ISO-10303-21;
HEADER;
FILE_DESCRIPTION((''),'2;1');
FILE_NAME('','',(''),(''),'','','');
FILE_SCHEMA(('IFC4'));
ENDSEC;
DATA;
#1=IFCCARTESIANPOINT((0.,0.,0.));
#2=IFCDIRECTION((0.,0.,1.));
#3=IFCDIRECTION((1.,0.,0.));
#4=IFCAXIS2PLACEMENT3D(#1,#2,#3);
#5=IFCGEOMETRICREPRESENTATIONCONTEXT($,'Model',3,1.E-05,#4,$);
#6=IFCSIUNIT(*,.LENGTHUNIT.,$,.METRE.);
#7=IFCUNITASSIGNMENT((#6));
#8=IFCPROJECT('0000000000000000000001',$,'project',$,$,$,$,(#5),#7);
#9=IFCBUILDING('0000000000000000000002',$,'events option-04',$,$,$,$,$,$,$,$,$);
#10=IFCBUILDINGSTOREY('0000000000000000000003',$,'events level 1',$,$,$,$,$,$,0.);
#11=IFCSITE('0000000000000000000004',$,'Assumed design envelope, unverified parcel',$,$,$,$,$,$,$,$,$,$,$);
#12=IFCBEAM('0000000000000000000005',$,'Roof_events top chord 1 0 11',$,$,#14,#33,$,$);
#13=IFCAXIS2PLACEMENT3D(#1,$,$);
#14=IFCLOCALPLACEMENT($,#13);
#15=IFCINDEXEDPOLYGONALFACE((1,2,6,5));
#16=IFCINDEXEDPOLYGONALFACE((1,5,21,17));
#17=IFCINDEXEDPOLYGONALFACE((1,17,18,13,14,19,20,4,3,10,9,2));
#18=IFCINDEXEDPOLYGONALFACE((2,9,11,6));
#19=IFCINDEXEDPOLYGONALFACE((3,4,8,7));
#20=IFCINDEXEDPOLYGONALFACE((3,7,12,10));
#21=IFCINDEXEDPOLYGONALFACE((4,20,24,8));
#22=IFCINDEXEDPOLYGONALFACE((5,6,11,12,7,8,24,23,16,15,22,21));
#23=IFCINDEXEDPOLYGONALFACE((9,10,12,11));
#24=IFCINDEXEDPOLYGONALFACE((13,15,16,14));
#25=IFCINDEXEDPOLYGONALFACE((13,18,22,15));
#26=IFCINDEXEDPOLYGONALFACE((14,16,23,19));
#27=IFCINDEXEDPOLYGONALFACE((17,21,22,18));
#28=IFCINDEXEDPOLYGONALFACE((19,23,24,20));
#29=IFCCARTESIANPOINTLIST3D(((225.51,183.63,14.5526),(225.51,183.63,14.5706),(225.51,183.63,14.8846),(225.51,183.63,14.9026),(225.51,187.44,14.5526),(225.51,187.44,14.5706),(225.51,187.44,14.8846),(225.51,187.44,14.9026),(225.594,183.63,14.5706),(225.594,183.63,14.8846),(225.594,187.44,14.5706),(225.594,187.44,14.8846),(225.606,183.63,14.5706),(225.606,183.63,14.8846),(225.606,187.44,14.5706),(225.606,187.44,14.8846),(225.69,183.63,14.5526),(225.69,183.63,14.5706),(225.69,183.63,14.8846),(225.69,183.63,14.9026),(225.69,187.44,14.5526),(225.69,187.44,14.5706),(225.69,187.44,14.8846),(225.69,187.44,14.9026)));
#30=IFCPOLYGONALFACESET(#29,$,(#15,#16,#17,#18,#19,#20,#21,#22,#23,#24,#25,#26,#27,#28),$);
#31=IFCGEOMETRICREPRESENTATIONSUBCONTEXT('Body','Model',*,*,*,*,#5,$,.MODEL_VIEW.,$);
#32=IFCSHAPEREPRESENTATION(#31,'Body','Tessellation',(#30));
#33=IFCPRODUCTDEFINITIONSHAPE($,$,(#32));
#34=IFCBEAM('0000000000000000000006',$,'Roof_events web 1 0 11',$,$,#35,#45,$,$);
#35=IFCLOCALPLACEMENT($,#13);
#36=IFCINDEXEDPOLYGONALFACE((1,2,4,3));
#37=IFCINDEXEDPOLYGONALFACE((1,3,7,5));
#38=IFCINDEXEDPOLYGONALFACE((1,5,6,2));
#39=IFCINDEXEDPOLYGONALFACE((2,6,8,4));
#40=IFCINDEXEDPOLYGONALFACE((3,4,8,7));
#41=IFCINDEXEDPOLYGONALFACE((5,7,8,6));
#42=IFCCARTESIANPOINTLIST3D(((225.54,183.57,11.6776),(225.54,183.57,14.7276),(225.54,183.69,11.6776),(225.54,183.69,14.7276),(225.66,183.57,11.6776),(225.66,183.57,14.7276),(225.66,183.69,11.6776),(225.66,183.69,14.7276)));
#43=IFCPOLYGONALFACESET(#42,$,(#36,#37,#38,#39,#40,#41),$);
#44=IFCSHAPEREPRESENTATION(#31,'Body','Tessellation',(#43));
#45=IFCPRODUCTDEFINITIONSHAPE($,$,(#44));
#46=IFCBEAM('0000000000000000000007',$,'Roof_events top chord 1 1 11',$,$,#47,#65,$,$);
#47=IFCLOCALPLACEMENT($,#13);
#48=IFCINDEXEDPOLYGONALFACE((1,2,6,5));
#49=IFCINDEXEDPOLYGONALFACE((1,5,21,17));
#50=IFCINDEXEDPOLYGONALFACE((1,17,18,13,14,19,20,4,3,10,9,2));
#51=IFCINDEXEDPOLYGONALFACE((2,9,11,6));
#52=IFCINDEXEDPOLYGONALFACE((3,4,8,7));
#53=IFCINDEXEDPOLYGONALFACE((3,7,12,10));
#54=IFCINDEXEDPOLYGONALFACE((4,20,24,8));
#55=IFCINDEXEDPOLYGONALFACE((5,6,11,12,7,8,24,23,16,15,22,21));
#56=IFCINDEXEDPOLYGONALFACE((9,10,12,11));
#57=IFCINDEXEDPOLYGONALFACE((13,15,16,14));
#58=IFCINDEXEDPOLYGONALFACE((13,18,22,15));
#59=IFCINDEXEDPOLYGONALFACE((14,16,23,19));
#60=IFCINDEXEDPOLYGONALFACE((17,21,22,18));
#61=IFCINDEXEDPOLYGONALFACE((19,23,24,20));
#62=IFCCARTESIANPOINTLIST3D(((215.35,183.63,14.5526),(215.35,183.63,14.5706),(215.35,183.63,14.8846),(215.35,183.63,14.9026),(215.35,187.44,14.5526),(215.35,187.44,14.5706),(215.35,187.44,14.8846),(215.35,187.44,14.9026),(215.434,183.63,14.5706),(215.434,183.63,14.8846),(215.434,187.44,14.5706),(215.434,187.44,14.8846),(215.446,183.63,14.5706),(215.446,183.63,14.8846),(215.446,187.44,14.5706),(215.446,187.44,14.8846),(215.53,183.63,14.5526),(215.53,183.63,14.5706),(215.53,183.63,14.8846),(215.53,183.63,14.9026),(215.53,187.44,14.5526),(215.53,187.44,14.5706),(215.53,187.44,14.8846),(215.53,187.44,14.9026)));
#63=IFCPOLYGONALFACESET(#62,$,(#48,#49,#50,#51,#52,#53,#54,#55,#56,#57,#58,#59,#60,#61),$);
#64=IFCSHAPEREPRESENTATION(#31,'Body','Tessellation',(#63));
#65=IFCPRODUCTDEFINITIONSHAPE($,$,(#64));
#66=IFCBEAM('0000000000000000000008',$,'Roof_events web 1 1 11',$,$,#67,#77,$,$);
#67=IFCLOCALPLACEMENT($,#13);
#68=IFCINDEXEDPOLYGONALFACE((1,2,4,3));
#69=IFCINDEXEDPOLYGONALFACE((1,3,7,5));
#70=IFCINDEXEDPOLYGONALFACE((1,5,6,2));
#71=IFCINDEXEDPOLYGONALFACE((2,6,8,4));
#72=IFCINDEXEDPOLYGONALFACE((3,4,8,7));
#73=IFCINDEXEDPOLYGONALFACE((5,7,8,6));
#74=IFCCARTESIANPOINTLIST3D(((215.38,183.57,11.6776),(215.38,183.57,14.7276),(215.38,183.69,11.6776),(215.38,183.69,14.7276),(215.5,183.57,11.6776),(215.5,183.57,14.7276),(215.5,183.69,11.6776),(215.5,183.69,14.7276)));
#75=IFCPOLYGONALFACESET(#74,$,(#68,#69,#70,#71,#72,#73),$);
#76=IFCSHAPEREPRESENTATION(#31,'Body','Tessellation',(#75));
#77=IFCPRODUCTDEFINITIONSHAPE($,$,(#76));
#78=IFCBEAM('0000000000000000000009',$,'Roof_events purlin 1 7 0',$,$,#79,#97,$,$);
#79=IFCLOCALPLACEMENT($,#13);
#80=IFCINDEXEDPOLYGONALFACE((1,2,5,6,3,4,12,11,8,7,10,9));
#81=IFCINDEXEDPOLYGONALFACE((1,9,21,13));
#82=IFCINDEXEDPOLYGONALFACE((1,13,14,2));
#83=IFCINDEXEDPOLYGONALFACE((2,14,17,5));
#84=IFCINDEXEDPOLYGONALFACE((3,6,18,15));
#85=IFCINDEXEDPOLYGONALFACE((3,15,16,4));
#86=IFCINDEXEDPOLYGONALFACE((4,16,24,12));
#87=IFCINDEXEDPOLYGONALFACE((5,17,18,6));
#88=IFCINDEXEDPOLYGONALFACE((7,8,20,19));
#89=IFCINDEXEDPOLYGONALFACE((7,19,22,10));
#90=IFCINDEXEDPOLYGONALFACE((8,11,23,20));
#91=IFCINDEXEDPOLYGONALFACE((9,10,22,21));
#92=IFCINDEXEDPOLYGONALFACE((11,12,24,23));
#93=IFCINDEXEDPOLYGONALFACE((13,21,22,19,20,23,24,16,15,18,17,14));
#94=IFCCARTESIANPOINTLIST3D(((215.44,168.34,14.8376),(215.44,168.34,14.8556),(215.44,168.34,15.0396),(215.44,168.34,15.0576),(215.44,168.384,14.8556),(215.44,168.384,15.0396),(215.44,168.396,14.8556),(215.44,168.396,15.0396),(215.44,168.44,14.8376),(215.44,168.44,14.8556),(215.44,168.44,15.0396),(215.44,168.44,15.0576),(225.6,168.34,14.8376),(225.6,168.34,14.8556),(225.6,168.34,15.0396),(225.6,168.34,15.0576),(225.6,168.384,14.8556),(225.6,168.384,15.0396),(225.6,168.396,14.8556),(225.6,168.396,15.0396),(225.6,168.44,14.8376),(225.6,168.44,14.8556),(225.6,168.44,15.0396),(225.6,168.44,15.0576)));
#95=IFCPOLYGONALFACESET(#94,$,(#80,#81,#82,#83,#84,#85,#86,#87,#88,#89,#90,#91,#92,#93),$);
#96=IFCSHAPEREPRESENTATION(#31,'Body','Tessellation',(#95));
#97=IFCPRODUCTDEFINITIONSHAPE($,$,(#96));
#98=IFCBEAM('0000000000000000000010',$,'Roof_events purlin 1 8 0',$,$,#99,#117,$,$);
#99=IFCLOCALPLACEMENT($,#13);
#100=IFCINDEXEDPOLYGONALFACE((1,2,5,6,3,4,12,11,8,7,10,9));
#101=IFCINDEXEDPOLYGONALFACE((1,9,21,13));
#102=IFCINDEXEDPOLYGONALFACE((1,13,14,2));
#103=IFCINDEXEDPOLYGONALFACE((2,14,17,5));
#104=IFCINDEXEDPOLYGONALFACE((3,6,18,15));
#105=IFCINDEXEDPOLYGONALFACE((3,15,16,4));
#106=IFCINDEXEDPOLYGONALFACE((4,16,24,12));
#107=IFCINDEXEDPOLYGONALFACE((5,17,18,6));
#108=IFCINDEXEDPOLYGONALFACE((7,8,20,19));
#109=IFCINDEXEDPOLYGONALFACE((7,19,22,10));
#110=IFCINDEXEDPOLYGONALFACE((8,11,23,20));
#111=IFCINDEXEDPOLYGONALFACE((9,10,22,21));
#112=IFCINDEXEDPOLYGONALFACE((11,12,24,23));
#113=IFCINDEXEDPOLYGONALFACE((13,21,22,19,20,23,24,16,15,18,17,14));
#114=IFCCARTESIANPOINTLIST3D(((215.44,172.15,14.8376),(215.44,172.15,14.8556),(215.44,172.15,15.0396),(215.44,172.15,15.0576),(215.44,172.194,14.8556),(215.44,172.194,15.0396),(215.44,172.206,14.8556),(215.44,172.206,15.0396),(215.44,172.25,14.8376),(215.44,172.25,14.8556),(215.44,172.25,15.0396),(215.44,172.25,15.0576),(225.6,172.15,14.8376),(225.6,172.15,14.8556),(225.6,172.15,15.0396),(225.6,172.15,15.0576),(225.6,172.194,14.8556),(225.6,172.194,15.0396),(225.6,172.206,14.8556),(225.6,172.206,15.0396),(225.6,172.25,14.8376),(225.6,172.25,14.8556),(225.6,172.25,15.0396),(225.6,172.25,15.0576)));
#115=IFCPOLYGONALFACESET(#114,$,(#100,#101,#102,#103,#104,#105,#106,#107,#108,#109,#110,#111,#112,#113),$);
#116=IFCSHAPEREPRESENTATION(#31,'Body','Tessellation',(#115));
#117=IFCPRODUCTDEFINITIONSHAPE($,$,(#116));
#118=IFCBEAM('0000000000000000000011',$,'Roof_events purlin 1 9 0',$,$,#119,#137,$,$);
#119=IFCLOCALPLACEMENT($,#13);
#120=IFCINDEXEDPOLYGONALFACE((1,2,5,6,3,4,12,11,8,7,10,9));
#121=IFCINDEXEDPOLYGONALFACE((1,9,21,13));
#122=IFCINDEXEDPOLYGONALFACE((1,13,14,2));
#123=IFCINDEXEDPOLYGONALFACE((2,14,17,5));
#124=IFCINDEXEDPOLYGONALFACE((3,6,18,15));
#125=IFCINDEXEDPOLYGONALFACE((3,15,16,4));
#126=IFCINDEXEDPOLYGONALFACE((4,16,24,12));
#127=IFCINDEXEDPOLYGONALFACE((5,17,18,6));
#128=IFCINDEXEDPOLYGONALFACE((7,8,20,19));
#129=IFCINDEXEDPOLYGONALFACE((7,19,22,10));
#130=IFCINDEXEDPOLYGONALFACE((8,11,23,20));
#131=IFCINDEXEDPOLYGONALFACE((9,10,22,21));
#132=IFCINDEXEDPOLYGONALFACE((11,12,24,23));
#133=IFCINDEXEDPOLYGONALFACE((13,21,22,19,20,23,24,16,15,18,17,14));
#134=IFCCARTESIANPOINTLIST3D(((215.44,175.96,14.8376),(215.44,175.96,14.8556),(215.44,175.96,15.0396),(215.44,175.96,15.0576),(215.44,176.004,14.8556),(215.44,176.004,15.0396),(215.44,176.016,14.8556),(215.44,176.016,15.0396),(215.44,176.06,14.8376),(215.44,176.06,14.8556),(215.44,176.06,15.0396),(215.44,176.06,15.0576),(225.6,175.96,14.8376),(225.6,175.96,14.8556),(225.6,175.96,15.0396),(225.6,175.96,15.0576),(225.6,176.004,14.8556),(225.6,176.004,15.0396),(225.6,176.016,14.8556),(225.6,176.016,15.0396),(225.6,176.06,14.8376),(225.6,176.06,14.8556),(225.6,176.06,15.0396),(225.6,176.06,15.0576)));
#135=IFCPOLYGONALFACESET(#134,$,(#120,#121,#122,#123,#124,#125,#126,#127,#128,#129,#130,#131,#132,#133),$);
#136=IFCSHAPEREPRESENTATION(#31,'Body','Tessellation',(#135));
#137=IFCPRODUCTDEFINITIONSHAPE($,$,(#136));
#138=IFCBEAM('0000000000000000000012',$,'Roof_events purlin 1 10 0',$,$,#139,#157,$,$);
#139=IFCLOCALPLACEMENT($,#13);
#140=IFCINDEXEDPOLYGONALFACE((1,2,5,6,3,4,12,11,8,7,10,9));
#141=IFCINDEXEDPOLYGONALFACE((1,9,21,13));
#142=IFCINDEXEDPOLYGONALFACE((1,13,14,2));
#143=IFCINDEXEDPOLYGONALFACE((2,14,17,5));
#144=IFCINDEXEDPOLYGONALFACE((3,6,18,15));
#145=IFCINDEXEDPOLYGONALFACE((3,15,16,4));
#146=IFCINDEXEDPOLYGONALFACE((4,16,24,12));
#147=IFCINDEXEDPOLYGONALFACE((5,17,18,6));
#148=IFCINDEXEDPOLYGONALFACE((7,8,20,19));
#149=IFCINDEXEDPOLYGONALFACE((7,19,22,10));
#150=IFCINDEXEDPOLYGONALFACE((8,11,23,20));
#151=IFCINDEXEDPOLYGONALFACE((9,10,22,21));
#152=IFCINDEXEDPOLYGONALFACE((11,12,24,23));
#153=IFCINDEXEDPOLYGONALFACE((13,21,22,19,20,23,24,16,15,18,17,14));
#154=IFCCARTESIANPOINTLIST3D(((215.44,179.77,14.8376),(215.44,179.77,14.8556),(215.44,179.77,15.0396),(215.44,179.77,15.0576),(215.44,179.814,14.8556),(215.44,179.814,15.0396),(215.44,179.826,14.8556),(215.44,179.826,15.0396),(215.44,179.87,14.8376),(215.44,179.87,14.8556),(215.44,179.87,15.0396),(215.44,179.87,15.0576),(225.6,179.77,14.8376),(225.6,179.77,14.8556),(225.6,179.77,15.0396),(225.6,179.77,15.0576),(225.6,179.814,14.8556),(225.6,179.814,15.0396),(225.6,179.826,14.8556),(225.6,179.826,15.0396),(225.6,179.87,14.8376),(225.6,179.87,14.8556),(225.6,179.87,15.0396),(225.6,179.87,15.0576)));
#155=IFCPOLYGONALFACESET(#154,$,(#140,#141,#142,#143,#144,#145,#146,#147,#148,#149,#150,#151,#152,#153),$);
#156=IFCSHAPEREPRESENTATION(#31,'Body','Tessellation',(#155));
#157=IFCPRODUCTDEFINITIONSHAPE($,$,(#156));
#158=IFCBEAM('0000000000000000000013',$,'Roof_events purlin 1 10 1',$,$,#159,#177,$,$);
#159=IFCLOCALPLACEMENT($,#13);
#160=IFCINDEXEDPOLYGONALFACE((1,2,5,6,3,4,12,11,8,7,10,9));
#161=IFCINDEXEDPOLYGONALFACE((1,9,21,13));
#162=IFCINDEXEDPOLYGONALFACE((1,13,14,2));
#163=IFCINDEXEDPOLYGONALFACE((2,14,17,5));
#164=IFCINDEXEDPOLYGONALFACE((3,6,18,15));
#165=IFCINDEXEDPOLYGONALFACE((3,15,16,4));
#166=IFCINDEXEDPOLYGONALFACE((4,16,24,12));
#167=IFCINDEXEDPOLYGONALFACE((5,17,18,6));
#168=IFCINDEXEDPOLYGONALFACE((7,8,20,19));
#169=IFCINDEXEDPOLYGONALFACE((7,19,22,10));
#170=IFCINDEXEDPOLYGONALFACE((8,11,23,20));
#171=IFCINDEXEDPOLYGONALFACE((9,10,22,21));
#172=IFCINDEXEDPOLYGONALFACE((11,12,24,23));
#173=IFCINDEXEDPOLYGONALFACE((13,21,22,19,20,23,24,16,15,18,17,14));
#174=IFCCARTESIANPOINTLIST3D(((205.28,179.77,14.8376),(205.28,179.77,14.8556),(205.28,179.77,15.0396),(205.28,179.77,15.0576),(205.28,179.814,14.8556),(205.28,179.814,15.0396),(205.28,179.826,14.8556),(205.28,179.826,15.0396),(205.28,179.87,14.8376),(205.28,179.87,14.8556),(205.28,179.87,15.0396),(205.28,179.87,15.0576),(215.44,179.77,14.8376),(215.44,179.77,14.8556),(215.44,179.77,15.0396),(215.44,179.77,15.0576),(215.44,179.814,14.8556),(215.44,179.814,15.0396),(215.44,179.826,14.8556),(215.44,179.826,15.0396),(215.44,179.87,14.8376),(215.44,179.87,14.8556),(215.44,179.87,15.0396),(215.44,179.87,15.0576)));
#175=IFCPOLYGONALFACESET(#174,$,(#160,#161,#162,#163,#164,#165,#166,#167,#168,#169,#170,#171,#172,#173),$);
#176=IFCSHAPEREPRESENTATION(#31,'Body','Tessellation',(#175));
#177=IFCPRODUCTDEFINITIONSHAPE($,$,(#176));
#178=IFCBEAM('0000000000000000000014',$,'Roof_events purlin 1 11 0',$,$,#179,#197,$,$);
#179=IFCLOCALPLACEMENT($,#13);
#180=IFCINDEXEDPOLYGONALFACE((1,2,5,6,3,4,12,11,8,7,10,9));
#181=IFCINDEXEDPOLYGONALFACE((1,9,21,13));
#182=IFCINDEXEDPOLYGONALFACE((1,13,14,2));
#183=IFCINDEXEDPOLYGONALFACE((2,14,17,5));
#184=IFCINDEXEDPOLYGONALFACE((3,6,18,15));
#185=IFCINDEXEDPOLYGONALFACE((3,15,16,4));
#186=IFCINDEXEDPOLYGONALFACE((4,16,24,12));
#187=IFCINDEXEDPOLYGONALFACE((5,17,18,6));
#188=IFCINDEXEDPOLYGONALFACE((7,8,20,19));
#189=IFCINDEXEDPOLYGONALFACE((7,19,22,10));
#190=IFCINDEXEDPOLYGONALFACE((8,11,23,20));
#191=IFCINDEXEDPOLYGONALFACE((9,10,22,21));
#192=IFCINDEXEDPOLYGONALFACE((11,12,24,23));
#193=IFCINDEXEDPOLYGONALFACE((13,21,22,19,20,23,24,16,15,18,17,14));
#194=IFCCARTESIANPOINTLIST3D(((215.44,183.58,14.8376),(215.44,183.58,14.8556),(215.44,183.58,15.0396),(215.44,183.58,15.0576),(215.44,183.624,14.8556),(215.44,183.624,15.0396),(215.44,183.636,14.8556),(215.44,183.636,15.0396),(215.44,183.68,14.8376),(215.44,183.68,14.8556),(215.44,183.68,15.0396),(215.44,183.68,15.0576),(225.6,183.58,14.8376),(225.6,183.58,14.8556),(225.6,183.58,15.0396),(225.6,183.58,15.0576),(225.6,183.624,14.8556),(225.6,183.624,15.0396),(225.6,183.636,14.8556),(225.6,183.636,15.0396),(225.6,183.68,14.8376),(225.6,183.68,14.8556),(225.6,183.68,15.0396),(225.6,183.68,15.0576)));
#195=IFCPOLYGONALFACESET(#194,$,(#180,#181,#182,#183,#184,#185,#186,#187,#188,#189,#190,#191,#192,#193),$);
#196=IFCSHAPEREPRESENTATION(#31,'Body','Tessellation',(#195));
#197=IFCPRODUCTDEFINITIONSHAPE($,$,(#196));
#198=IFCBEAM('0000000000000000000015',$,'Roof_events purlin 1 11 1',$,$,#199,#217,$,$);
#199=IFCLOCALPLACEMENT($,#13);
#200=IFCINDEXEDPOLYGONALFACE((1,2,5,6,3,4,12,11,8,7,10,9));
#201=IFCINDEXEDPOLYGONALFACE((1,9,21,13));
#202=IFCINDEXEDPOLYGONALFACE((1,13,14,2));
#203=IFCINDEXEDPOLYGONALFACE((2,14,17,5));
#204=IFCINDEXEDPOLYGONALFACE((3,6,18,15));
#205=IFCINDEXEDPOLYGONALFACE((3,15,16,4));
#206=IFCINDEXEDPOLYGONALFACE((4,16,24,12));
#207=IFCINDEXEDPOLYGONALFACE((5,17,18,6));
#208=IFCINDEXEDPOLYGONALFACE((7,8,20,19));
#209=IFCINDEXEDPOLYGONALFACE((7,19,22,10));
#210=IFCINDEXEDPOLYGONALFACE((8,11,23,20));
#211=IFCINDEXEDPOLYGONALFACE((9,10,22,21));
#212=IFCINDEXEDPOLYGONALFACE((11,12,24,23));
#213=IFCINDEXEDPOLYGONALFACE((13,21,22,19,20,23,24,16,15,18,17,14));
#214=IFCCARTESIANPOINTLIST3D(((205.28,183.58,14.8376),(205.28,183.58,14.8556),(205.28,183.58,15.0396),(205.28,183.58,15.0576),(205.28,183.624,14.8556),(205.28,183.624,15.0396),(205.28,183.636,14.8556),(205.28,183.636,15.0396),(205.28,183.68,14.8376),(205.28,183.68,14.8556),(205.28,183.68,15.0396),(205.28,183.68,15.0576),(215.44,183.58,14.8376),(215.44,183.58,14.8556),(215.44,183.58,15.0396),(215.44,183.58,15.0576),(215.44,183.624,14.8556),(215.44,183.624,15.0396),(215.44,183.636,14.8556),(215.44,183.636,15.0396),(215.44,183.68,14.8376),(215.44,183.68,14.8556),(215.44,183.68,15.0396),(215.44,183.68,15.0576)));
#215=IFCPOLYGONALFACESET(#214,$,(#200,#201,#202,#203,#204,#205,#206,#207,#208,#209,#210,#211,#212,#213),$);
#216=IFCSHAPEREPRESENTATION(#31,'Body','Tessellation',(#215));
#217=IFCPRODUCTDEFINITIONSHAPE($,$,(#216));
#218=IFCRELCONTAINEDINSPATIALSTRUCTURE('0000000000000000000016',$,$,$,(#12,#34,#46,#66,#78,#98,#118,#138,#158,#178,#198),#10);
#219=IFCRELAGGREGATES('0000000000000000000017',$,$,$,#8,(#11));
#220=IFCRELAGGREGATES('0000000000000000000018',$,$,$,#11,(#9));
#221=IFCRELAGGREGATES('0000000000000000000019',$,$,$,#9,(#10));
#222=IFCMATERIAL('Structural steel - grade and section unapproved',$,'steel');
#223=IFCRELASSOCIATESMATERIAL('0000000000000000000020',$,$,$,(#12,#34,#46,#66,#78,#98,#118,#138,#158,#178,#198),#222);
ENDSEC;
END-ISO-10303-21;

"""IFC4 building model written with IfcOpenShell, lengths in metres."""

from ifc_helpers import new_model, si_unit, frame, origin_with_axes, place, context, subcontext, project, spatial, rectangle, i_section, extrude, material, element, save


model = new_model("IFC4")

# Units and contexts
model_context = context("Model", 3, precision=1e-05, world=origin_with_axes())
body_context = subcontext(model_context, "Body", "Model", "MODEL_VIEW")
ifc_project = project(units=[si_unit("LENGTHUNIT", "METRE")], contexts=[model_context])

# Site, building, storey
site = spatial("IfcSite", under=ifc_project, Name="Assumed design envelope, unverified parcel")
building = spatial("IfcBuilding", under=site, Name="events option-04")
storey = spatial("IfcBuildingStorey", under=building, Name="events level 1", Elevation=0.0)

# Shared definitions
ifc_material_1 = material(Name="Structural steel - grade and section unapproved", Category="steel")

# Beams
beam_1_placement = place(None, frame((225.6, 183.63, 14.7276), z_axis=(0.0, 1.0, 0.0), x_axis=(-1.0, 0.0, 0.0)))
element("IfcBeam", 1, at=beam_1_placement, inside=storey, material=ifc_material_1, Name="Roof_events top chord 1 0 11", context=body_context, shape_type="SweptSolid", body=[
    extrude(i_section(OverallWidth=0.18, OverallDepth=0.35, WebThickness=0.012, FlangeThickness=0.018, FilletRadius=0.0), origin_with_axes(), (0.0, 0.0, 1.0), 3.81),
])
beam_2_placement = place(None, frame((225.6, 183.63, 11.6776), z_axis=(0.0, 0.0, 1.0), x_axis=(-1.0, 0.0, 0.0)))
element("IfcBeam", 2, at=beam_2_placement, inside=storey, material=ifc_material_1, Name="Roof_events web 1 0 11", context=body_context, shape_type="SweptSolid", body=[
    extrude(rectangle(XDim=0.12, YDim=0.12), origin_with_axes(), (0.0, 0.0, 1.0), 3.05),
])
beam_3_placement = place(None, frame((215.44, 183.63, 14.7276), z_axis=(0.0, 1.0, 0.0), x_axis=(-1.0, 0.0, 0.0)))
element("IfcBeam", 3, at=beam_3_placement, inside=storey, material=ifc_material_1, Name="Roof_events top chord 1 1 11", context=body_context, shape_type="SweptSolid", body=[
    extrude(i_section(OverallWidth=0.18, OverallDepth=0.35, WebThickness=0.012, FlangeThickness=0.018, FilletRadius=0.0), origin_with_axes(), (0.0, 0.0, 1.0), 3.81),
])
beam_4_placement = place(None, frame((215.44, 183.63, 11.6776), z_axis=(0.0, 0.0, 1.0), x_axis=(-1.0, 0.0, 0.0)))
element("IfcBeam", 4, at=beam_4_placement, inside=storey, material=ifc_material_1, Name="Roof_events web 1 1 11", context=body_context, shape_type="SweptSolid", body=[
    extrude(rectangle(XDim=0.12, YDim=0.12), origin_with_axes(), (0.0, 0.0, 1.0), 3.05),
])
for number, where, z_axis, x_axis, name in (
    (5, (225.6, 168.39, 14.9476), (-1.0, 0.0, 0.0), (0.0, -1.0, 0.0), "Roof_events purlin 1 7 0"),
    (6, (225.6, 172.2, 14.9476), (-1.0, 0.0, 0.0), (0.0, -1.0, 0.0), "Roof_events purlin 1 8 0"),
    (7, (225.6, 176.01, 14.9476), (-1.0, 0.0, 0.0), (0.0, -1.0, 0.0), "Roof_events purlin 1 9 0"),
    (8, (225.6, 179.82, 14.9476), (-1.0, 0.0, 0.0), (0.0, -1.0, 0.0), "Roof_events purlin 1 10 0"),
    (9, (215.44, 179.82, 14.9476), (-1.0, 0.0, 0.0), (0.0, -1.0, 0.0), "Roof_events purlin 1 10 1"),
    (10, (225.6, 183.63, 14.9476), (-1.0, 0.0, 0.0), (0.0, -1.0, 0.0), "Roof_events purlin 1 11 0"),
    (11, (215.44, 183.63, 14.9476), (-1.0, 0.0, 0.0), (0.0, -1.0, 0.0), "Roof_events purlin 1 11 1"),
):
    element("IfcBeam", number, at=place(None, frame(where, z_axis=z_axis, x_axis=x_axis)), inside=storey, material=ifc_material_1, Name=name, context=body_context, shape_type="SweptSolid", body=[
        extrude(i_section(OverallWidth=0.1, OverallDepth=0.22, WebThickness=0.012, FlangeThickness=0.018, FilletRadius=0.0), origin_with_axes(), (0.0, 0.0, 1.0), 10.16),
    ])

save(model, "model.ifc")
